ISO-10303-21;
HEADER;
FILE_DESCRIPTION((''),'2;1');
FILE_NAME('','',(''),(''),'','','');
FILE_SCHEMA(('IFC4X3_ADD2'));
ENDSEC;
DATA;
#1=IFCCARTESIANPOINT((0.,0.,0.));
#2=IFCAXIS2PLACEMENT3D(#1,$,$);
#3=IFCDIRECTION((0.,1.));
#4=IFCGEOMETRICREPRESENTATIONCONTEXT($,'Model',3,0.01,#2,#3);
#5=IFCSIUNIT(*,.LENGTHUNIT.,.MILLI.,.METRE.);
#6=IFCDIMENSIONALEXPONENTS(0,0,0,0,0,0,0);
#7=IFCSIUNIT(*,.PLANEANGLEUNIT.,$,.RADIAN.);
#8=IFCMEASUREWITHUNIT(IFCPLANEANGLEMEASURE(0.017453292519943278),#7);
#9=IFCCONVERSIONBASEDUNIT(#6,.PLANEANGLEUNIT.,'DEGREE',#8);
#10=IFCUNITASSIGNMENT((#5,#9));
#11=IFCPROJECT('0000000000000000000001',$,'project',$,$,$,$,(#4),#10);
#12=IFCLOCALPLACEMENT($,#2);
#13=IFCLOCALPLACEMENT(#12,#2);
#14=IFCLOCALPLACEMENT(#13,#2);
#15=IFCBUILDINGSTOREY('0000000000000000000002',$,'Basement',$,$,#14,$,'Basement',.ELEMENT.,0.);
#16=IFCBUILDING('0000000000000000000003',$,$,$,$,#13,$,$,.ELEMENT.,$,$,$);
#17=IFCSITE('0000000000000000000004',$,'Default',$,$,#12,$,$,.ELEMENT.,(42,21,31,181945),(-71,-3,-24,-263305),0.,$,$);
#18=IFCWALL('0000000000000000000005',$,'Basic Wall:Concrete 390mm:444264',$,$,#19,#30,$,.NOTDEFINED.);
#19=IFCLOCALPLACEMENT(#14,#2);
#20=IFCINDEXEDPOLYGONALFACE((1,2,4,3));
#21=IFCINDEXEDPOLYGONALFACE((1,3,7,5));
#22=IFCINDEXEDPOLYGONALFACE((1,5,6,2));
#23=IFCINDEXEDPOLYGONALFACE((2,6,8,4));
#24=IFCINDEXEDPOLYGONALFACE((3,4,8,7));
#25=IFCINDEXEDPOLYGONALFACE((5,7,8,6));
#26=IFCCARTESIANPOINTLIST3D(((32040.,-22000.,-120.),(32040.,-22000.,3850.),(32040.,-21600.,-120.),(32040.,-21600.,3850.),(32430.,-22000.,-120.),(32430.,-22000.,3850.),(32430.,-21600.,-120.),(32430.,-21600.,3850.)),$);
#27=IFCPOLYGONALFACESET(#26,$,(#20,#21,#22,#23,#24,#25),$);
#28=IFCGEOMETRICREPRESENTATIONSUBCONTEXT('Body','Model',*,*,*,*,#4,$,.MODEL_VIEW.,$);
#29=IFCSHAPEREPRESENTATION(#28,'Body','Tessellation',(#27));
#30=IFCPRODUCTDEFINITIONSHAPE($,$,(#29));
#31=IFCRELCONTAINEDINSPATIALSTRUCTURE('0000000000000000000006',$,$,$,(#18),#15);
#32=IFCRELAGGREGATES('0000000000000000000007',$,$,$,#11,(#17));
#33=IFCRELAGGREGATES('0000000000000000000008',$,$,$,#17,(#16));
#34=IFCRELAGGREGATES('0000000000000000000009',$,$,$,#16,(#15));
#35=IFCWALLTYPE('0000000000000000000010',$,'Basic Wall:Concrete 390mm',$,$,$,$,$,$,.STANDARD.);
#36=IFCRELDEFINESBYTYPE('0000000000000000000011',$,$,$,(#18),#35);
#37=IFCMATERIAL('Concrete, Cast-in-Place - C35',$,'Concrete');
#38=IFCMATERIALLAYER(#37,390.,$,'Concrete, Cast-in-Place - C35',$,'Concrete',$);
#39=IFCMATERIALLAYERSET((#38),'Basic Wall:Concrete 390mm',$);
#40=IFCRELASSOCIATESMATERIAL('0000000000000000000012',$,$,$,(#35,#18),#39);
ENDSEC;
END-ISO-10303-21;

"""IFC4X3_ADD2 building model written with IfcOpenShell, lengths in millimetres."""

from ifc_helpers import new_model, entity, si_unit, converted_unit, direction, frame, frame_2d, origin, place, context, subcontext, project, spatial, rectangle, extrude, material, layer, layer_set, type_object, element, save


model = new_model("IFC4X3_ADD2")

# Units and contexts
model_context = context("Model", 3, precision=0.01, world=origin(), true_north=direction((0.0, 1.0)))
body_context = subcontext(model_context, "Body", "Model", "MODEL_VIEW")
ifc_project = project(units=[si_unit("LENGTHUNIT", "METRE", prefix="MILLI"), converted_unit("PLANEANGLEUNIT", "DEGREE", entity("IfcPlaneAngleMeasure", 0.017453292519943278), si_unit("PLANEANGLEUNIT", "RADIAN"), dimensions=[0, 0, 0, 0, 0, 0, 0])], contexts=[model_context])

# Site, building, storey
site_placement = place(None, origin())
site = spatial("IfcSite", under=ifc_project, at=site_placement, Name="Default", CompositionType="ELEMENT", RefLatitude=(42, 21, 31, 181945), RefLongitude=(-71, -3, -24, -263305), RefElevation=0.0)
building_placement = place(site_placement, origin())
building = spatial("IfcBuilding", under=site, at=building_placement, CompositionType="ELEMENT")
storey_placement = place(building_placement, origin())
storey = spatial("IfcBuildingStorey", under=building, at=storey_placement, Name="Basement", LongName="Basement", CompositionType="ELEMENT", Elevation=0.0)

# Shared definitions
ifc_material = material(Name="Concrete, Cast-in-Place - C35", Category="Concrete")

# Wall
ifc_layer_1 = layer(ifc_material, 390.0, Name="Concrete, Cast-in-Place - C35", Category="Concrete")
ifc_layer_set_1 = layer_set([ifc_layer_1], Name="Basic Wall:Concrete 390mm")
wall_type_1 = type_object("IfcWallType", Name="Basic Wall:Concrete 390mm", PredefinedType="STANDARD", material=ifc_layer_set_1)
wall_1_placement = place(storey_placement, frame((32235.0, -21600.0, -120.0), z_axis=(0.0, 0.0, 1.0), x_axis=(0.0, -1.0, 0.0)))
element("IfcWall", 1, at=wall_1_placement, inside=storey, type_object=wall_type_1, material=ifc_layer_set_1, Name="Basic Wall:Concrete 390mm:444264", PredefinedType="NOTDEFINED", context=body_context, shape_type="SweptSolid", body=[
    extrude(rectangle(XDim=400.0, YDim=390.0, at=frame_2d((200.0, 0.0), x_axis=(-1.0, 0.0))), origin(), (0.0, 0.0, 1.0), 3970.0),
])

save(model, "model.ifc")
